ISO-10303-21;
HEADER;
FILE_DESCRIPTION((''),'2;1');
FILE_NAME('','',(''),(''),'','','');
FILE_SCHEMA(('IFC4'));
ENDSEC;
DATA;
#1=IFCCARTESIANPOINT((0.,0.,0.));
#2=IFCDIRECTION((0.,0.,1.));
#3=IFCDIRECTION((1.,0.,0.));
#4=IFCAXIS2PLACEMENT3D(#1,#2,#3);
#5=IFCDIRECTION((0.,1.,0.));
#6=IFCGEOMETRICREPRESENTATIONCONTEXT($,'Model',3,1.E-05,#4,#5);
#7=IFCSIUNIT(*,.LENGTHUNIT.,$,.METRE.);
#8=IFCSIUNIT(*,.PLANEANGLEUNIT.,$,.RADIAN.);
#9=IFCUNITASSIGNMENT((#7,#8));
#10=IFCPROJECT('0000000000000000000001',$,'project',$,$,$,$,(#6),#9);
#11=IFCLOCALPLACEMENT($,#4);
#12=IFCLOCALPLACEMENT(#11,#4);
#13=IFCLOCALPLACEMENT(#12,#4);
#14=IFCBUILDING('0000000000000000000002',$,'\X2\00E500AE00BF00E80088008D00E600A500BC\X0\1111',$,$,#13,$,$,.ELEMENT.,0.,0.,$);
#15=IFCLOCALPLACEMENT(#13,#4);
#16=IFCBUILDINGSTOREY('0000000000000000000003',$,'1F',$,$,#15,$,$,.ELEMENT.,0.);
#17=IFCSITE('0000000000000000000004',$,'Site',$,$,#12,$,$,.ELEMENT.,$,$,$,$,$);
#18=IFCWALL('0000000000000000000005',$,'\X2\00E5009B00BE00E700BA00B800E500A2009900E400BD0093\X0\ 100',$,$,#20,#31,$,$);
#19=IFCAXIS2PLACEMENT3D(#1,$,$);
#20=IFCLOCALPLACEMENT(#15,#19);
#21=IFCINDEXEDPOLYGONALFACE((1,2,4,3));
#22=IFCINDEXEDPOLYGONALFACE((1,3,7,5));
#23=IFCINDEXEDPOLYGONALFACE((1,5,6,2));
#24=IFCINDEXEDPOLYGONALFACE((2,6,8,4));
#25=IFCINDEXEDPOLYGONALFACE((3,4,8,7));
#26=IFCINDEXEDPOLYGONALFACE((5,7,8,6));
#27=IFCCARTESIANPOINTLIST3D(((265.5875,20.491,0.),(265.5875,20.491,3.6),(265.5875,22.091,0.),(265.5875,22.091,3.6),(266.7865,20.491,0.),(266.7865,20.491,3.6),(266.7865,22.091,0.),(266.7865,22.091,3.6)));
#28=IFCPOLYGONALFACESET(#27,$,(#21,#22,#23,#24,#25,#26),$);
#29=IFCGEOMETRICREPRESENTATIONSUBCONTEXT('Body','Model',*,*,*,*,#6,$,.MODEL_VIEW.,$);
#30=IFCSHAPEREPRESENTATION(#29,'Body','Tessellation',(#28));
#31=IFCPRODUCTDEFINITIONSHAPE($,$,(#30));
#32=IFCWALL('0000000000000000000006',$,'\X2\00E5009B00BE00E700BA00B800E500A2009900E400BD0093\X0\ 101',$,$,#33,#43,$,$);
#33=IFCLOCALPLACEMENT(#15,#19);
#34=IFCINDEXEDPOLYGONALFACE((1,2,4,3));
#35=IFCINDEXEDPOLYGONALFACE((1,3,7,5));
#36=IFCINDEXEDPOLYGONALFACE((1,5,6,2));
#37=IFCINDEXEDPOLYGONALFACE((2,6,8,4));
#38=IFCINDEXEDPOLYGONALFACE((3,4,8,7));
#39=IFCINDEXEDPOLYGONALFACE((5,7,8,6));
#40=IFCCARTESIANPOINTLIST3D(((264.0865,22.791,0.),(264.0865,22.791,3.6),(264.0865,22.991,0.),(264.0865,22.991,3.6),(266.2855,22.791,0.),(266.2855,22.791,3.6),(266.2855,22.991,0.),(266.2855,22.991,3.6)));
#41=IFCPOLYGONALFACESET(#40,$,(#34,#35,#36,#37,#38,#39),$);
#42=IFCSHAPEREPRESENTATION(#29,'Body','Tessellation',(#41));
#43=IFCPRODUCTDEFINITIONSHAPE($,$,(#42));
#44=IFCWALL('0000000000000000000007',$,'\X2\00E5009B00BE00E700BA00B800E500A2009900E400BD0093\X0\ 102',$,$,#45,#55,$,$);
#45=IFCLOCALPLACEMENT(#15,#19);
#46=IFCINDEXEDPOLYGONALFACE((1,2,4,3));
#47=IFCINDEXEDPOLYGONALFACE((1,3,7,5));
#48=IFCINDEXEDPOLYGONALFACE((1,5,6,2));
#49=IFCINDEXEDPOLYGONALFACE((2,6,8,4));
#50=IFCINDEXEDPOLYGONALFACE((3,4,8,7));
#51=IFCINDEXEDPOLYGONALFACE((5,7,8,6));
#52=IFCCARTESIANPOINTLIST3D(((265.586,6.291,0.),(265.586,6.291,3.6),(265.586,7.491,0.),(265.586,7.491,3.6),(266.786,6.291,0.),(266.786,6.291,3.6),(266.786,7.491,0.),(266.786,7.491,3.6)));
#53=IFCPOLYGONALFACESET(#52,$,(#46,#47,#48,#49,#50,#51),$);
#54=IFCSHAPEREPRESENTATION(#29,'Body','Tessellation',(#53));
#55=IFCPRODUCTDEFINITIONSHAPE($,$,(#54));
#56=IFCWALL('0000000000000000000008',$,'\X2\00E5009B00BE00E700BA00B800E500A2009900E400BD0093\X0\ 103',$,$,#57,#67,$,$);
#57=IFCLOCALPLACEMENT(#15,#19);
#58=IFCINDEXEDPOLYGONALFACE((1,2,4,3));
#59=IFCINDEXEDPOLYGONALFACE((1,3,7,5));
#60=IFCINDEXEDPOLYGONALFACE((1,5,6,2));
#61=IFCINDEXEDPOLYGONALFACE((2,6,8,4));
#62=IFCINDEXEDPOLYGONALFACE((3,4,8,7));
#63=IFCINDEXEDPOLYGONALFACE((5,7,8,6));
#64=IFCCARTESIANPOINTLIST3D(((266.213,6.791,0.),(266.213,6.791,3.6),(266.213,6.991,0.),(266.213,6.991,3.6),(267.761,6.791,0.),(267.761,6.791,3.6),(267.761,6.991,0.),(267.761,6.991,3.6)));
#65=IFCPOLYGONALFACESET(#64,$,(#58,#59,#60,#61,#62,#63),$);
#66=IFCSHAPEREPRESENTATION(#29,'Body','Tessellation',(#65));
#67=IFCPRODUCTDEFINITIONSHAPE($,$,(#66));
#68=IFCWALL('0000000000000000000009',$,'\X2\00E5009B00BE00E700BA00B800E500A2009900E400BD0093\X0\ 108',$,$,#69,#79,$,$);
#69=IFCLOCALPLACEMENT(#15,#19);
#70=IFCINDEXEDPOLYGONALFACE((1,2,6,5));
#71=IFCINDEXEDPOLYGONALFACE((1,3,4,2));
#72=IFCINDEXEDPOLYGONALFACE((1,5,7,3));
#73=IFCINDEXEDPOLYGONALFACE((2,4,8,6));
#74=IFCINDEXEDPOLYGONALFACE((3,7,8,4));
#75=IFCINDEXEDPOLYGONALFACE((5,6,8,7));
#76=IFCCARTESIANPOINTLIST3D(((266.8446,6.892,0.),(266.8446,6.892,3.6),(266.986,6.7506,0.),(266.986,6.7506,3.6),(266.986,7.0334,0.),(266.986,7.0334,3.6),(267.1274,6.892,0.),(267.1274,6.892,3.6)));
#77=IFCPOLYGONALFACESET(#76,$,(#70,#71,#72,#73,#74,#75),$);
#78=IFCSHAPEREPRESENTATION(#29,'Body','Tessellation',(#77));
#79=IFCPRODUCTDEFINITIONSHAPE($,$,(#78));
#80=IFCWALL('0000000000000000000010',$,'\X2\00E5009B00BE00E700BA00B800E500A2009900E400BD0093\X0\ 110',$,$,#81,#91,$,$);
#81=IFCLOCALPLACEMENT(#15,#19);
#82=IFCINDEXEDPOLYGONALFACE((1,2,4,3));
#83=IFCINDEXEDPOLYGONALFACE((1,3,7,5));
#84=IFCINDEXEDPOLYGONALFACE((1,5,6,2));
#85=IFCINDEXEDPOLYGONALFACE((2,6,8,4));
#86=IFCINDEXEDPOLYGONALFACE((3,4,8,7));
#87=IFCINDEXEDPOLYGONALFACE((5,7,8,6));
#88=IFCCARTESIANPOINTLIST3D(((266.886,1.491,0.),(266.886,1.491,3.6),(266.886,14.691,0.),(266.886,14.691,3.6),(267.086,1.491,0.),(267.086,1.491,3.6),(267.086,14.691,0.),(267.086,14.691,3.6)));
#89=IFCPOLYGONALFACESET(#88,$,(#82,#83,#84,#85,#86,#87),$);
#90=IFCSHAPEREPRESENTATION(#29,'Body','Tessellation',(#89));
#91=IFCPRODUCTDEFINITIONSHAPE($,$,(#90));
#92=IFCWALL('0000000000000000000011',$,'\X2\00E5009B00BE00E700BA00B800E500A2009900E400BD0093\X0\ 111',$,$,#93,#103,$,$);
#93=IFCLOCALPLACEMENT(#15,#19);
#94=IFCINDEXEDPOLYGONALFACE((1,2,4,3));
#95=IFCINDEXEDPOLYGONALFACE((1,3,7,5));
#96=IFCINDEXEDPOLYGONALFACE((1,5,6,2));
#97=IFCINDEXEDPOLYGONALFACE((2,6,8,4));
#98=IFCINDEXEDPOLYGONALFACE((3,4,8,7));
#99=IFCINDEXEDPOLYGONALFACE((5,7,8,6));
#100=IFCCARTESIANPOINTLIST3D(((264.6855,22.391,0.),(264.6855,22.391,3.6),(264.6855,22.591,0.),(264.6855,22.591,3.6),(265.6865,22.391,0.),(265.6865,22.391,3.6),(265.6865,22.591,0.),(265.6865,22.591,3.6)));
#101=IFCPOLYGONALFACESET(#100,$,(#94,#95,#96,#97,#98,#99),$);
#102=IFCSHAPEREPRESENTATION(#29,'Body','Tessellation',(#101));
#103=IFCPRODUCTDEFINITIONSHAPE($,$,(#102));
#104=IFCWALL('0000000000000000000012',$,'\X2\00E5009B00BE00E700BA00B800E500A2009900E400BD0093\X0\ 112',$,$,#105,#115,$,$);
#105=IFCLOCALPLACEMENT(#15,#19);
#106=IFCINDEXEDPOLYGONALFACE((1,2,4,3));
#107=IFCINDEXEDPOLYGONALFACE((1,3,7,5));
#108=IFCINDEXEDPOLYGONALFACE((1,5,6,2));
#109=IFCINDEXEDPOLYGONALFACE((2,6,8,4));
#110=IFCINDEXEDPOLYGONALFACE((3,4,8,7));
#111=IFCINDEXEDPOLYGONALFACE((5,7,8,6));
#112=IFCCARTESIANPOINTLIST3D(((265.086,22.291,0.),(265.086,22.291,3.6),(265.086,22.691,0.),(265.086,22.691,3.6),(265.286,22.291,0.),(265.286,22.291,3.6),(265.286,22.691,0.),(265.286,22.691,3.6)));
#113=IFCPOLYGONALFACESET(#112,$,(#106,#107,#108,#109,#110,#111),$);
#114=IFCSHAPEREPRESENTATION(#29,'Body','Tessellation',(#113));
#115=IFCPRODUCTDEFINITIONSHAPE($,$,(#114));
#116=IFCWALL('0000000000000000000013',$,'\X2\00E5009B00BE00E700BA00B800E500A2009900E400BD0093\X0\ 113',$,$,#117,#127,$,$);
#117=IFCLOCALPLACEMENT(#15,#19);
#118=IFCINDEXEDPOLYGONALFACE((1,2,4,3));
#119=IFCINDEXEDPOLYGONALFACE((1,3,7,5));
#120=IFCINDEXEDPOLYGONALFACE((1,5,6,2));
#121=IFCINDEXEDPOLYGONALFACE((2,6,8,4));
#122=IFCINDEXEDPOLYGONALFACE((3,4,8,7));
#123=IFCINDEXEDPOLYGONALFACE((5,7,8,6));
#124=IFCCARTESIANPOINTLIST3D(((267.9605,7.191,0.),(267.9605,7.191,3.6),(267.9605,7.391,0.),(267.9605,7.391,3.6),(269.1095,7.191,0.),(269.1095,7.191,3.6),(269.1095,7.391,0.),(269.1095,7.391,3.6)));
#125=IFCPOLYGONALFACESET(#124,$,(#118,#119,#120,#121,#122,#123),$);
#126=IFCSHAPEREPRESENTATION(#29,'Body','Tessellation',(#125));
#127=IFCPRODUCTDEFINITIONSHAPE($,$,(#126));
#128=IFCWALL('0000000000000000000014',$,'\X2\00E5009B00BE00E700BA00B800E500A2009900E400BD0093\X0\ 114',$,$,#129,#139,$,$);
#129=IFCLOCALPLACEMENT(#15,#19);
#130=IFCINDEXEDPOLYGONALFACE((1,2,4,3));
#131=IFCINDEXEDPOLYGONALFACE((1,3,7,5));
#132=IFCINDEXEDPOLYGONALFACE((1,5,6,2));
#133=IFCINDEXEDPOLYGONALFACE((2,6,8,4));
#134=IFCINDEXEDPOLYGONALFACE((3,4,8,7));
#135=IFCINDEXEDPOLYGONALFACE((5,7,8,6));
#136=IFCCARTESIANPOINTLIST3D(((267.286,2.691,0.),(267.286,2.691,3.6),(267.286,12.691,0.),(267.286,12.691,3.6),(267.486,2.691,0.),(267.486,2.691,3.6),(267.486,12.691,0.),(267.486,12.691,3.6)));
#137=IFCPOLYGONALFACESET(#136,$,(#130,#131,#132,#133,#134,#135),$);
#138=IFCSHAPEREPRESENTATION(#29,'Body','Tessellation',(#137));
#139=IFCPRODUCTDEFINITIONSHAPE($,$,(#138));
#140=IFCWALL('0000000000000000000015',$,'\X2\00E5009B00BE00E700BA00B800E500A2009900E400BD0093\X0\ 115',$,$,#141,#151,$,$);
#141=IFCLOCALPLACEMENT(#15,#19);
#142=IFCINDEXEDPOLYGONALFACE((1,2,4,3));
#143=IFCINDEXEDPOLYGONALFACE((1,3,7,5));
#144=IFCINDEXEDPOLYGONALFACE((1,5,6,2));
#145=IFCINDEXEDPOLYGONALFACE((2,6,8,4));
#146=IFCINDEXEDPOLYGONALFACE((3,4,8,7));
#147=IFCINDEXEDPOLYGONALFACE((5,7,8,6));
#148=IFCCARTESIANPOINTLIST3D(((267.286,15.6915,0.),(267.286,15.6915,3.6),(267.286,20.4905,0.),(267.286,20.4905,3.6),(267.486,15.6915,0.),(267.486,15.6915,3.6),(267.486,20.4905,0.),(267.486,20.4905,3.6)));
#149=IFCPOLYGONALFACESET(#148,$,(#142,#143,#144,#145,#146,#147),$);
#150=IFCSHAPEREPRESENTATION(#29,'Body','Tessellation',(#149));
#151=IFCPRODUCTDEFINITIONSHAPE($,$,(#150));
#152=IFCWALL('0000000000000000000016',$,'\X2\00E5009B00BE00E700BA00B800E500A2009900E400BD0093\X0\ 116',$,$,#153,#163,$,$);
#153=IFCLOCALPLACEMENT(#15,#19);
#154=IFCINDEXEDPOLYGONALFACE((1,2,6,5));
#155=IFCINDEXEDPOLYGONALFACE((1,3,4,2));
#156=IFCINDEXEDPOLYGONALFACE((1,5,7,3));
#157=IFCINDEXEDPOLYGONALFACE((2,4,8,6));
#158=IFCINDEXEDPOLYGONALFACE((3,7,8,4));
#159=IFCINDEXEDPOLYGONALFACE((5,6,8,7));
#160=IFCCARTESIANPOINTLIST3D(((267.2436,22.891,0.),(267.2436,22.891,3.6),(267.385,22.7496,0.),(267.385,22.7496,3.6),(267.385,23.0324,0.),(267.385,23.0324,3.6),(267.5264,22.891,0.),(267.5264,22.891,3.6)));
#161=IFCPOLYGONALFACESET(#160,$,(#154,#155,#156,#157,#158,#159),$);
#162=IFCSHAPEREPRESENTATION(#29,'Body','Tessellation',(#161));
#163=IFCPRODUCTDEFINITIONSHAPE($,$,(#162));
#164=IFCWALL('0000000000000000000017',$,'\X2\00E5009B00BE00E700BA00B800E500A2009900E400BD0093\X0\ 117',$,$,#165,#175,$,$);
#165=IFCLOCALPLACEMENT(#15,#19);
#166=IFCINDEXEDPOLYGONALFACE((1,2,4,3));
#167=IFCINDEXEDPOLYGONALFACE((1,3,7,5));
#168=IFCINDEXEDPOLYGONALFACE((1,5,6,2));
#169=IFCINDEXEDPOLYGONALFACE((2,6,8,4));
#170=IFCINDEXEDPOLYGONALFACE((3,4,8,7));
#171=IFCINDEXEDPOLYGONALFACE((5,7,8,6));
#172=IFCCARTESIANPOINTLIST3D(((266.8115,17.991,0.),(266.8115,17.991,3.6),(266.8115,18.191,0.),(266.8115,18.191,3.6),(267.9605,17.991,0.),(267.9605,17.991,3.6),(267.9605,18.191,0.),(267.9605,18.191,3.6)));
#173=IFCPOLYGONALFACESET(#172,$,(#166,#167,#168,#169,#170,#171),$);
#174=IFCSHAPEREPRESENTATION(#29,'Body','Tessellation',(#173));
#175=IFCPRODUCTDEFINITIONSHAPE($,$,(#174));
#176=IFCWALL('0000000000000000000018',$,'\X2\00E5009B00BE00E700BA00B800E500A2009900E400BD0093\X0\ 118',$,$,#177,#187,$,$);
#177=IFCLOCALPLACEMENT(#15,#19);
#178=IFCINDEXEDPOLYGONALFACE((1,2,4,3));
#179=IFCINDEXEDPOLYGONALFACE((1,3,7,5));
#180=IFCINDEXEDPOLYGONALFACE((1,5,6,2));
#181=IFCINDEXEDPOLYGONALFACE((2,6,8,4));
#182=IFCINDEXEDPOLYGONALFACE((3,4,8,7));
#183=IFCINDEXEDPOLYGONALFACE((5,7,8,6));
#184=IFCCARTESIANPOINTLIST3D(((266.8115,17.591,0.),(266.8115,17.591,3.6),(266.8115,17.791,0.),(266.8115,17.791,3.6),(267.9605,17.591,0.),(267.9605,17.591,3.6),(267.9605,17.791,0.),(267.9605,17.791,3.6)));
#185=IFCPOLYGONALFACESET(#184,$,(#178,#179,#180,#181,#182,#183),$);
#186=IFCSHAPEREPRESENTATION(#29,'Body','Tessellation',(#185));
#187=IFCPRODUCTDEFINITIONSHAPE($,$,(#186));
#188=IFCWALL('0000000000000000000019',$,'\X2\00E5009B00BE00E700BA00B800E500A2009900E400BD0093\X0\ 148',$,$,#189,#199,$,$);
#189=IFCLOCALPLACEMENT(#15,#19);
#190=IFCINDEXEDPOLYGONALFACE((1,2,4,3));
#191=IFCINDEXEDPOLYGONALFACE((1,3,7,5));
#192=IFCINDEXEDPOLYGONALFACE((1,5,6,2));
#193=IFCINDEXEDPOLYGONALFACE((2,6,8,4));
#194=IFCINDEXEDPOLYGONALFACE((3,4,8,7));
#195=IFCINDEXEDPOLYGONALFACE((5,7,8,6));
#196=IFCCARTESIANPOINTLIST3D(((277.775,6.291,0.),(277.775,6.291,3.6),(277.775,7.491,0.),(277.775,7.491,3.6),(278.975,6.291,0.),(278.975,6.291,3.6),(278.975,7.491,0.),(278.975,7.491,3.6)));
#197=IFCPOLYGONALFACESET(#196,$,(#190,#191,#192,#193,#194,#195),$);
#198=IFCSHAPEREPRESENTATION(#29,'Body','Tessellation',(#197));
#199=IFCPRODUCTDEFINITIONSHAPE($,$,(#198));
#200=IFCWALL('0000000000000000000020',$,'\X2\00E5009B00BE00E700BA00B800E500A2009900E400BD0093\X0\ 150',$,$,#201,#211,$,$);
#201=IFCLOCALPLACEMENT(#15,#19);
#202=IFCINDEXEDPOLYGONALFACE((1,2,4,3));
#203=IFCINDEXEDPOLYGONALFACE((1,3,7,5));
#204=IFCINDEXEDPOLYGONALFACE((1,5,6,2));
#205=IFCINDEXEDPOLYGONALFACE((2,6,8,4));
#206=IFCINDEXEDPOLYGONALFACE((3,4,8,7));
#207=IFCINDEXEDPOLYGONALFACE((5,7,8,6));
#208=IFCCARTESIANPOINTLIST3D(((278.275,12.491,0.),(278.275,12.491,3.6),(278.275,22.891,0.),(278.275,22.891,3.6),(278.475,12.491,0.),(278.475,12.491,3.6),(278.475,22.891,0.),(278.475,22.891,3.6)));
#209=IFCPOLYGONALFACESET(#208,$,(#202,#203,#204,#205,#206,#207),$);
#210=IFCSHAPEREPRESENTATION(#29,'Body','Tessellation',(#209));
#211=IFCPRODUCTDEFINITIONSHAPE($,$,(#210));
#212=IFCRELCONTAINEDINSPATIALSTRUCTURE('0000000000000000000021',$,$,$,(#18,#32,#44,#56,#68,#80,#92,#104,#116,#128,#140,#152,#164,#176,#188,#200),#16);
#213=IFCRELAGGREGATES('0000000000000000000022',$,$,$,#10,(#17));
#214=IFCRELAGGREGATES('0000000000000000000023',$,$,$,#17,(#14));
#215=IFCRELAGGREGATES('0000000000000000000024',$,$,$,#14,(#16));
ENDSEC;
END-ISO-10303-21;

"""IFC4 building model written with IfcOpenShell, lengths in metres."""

from ifc_helpers import new_model, si_unit, direction, frame, frame_2d, origin_with_axes, place, context, subcontext, project, spatial, rectangle, extrude, element, save


model = new_model("IFC4")

# Units and contexts
model_context = context("Model", 3, precision=1e-05, world=origin_with_axes(), true_north=direction((0.0, 1.0, 0.0)))
body_context = subcontext(model_context, "Body", "Model", "MODEL_VIEW")
ifc_project = project(units=[si_unit("LENGTHUNIT", "METRE"), si_unit("PLANEANGLEUNIT", "RADIAN")], contexts=[model_context])

# Site, building, storey
placement = place(None, origin_with_axes())
site_placement = place(placement, origin_with_axes())
site = spatial("IfcSite", under=ifc_project, at=site_placement, Name="Site", CompositionType="ELEMENT")
building_placement = place(site_placement, origin_with_axes())
building = spatial("IfcBuilding", under=site, at=building_placement, Name="å®¿è\u0088\u008dæ¥¼1111", CompositionType="ELEMENT", ElevationOfRefHeight=0.0, ElevationOfTerrain=0.0)
storey_placement = place(building_placement, origin_with_axes())
storey = spatial("IfcBuildingStorey", under=building, at=storey_placement, Name="1F", CompositionType="ELEMENT", Elevation=0.0)

# Walls
wall_1_placement = place(storey_placement, frame((266.187, 21.291, 0.0), z_axis=(0.0, 0.0, 1.0), x_axis=(1.0, 0.0, 0.0)))
element("IfcWall", 1, at=wall_1_placement, inside=storey, Name="å\u009b¾çº¸å¢\u0099ä½\u0093 100", context=body_context, shape_type="SweptSolid", body=[
    extrude(rectangle(XDim=1.199, YDim=1.6, at=frame_2d((0.0, 0.0), x_axis=(1.0, 0.0, 0.0))), frame((0.0, 0.0, 0.0), z_axis=(0.0, 0.0, 1.0)), (0.0, 0.0, 1.0), 3.6),
])
wall_2_placement = place(storey_placement, frame((265.186, 22.891, 0.0), z_axis=(0.0, 0.0, 1.0), x_axis=(1.0, 0.0, 0.0)))
element("IfcWall", 2, at=wall_2_placement, inside=storey, Name="å\u009b¾çº¸å¢\u0099ä½\u0093 101", context=body_context, shape_type="SweptSolid", body=[
    extrude(rectangle(XDim=2.199, YDim=0.2, at=frame_2d((0.0, 0.0), x_axis=(1.0, 0.0, 0.0))), frame((0.0, 0.0, 0.0), z_axis=(0.0, 0.0, 1.0)), (0.0, 0.0, 1.0), 3.6),
])
wall_3_placement = place(storey_placement, frame((266.186, 6.891, 0.0), z_axis=(0.0, 0.0, 1.0), x_axis=(1.0, 0.0, 0.0)))
element("IfcWall", 3, at=wall_3_placement, inside=storey, Name="å\u009b¾çº¸å¢\u0099ä½\u0093 102", context=body_context, shape_type="SweptSolid", body=[
    extrude(rectangle(XDim=1.2, YDim=1.2, at=frame_2d((0.0, 0.0), x_axis=(1.0, 0.0, 0.0))), frame((0.0, 0.0, 0.0), z_axis=(0.0, 0.0, 1.0)), (0.0, 0.0, 1.0), 3.6),
])
wall_4_placement = place(storey_placement, frame((266.987, 6.891, 0.0), z_axis=(0.0, 0.0, 1.0), x_axis=(1.0, 0.0, 0.0)))
element("IfcWall", 4, at=wall_4_placement, inside=storey, Name="å\u009b¾çº¸å¢\u0099ä½\u0093 103", context=body_context, shape_type="SweptSolid", body=[
    extrude(rectangle(XDim=1.548, YDim=0.2, at=frame_2d((0.0, 0.0), x_axis=(1.0, 0.0, 0.0))), frame((0.0, 0.0, 0.0), z_axis=(0.0, 0.0, 1.0)), (0.0, 0.0, 1.0), 3.6),
])
wall_5_placement = place(storey_placement, frame((266.986, 6.892, 0.0), z_axis=(0.0, 0.0, 1.0), x_axis=(0.707107, -0.707107, 0.0)))
element("IfcWall", 5, at=wall_5_placement, inside=storey, Name="å\u009b¾çº¸å¢\u0099ä½\u0093 108", context=body_context, shape_type="SweptSolid", body=[
    extrude(rectangle(XDim=0.2, YDim=0.2, at=frame_2d((0.0, 0.0), x_axis=(1.0, 0.0, 0.0))), frame((0.0, 0.0, 0.0), z_axis=(0.0, 0.0, 1.0)), (0.0, 0.0, 1.0), 3.6),
])
wall_6_placement = place(storey_placement, frame((266.986, 8.091, 0.0), z_axis=(0.0, 0.0, 1.0), x_axis=(0.0, 1.0, 0.0)))
element("IfcWall", 6, at=wall_6_placement, inside=storey, Name="å\u009b¾çº¸å¢\u0099ä½\u0093 110", context=body_context, shape_type="SweptSolid", body=[
    extrude(rectangle(XDim=13.2, YDim=0.2, at=frame_2d((0.0, 0.0), x_axis=(1.0, 0.0, 0.0))), frame((0.0, 0.0, 0.0), z_axis=(0.0, 0.0, 1.0)), (0.0, 0.0, 1.0), 3.6),
])
wall_7_placement = place(storey_placement, frame((265.186, 22.491, 0.0), z_axis=(0.0, 0.0, 1.0), x_axis=(1.0, 0.0, 0.0)))
element("IfcWall", 7, at=wall_7_placement, inside=storey, Name="å\u009b¾çº¸å¢\u0099ä½\u0093 111", context=body_context, shape_type="SweptSolid", body=[
    extrude(rectangle(XDim=1.001, YDim=0.2, at=frame_2d((0.0, 0.0), x_axis=(1.0, 0.0, 0.0))), frame((0.0, 0.0, 0.0), z_axis=(0.0, 0.0, 1.0)), (0.0, 0.0, 1.0), 3.6),
])
wall_8_placement = place(storey_placement, frame((265.186, 22.491, 0.0), z_axis=(0.0, 0.0, 1.0), x_axis=(0.0, 1.0, 0.0)))
element("IfcWall", 8, at=wall_8_placement, inside=storey, Name="å\u009b¾çº¸å¢\u0099ä½\u0093 112", context=body_context, shape_type="SweptSolid", body=[
    extrude(rectangle(XDim=0.4, YDim=0.2, at=frame_2d((0.0, 0.0), x_axis=(1.0, 0.0, 0.0))), frame((0.0, 0.0, 0.0), z_axis=(0.0, 0.0, 1.0)), (0.0, 0.0, 1.0), 3.6),
])
wall_9_placement = place(storey_placement, frame((268.535, 7.291, 0.0), z_axis=(0.0, 0.0, 1.0), x_axis=(-1.0, 0.0, 0.0)))
element("IfcWall", 9, at=wall_9_placement, inside=storey, Name="å\u009b¾çº¸å¢\u0099ä½\u0093 113", context=body_context, shape_type="SweptSolid", body=[
    extrude(rectangle(XDim=1.149, YDim=0.2, at=frame_2d((0.0, 0.0), x_axis=(1.0, 0.0, 0.0))), frame((0.0, 0.0, 0.0), z_axis=(0.0, 0.0, 1.0)), (0.0, 0.0, 1.0), 3.6),
])
wall_10_placement = place(storey_placement, frame((267.386, 7.691, 0.0), z_axis=(0.0, 0.0, 1.0), x_axis=(0.0, 1.0, 0.0)))
element("IfcWall", 10, at=wall_10_placement, inside=storey, Name="å\u009b¾çº¸å¢\u0099ä½\u0093 114", context=body_context, shape_type="SweptSolid", body=[
    extrude(rectangle(XDim=10.0, YDim=0.2, at=frame_2d((0.0, 0.0), x_axis=(1.0, 0.0, 0.0))), frame((0.0, 0.0, 0.0), z_axis=(0.0, 0.0, 1.0)), (0.0, 0.0, 1.0), 3.6),
])
wall_11_placement = place(storey_placement, frame((267.386, 18.091, 0.0), z_axis=(0.0, 0.0, 1.0), x_axis=(0.0, 1.0, 0.0)))
element("IfcWall", 11, at=wall_11_placement, inside=storey, Name="å\u009b¾çº¸å¢\u0099ä½\u0093 115", context=body_context, shape_type="SweptSolid", body=[
    extrude(rectangle(XDim=4.799, YDim=0.2, at=frame_2d((0.0, 0.0), x_axis=(1.0, 0.0, 0.0))), frame((0.0, 0.0, 0.0), z_axis=(0.0, 0.0, 1.0)), (0.0, 0.0, 1.0), 3.6),
])
wall_12_placement = place(storey_placement, frame((267.385, 22.891, 0.0), z_axis=(0.0, 0.0, 1.0), x_axis=(0.707107, -0.707107, 0.0)))
element("IfcWall", 12, at=wall_12_placement, inside=storey, Name="å\u009b¾çº¸å¢\u0099ä½\u0093 116", context=body_context, shape_type="SweptSolid", body=[
    extrude(rectangle(XDim=0.2, YDim=0.2, at=frame_2d((0.0, 0.0), x_axis=(1.0, 0.0, 0.0))), frame((0.0, 0.0, 0.0), z_axis=(0.0, 0.0, 1.0)), (0.0, 0.0, 1.0), 3.6),
])
for number, where, z_axis, x_axis, name in (
    (13, (267.386, 18.091, 0.0), (0.0, 0.0, 1.0), (1.0, 0.0, 0.0), "å\u009b¾çº¸å¢\u0099ä½\u0093 117"),
    (14, (267.386, 17.691, 0.0), (0.0, 0.0, 1.0), (1.0, 0.0, 0.0), "å\u009b¾çº¸å¢\u0099ä½\u0093 118"),
):
    element("IfcWall", number, at=place(storey_placement, frame(where, z_axis=z_axis, x_axis=x_axis)), inside=storey, Name=name, context=body_context, shape_type="SweptSolid", body=[
        extrude(rectangle(XDim=1.149, YDim=0.2, at=frame_2d((0.0, 0.0), x_axis=(1.0, 0.0, 0.0))), frame((0.0, 0.0, 0.0), z_axis=(0.0, 0.0, 1.0)), (0.0, 0.0, 1.0), 3.6),
    ])
wall_13_placement = place(storey_placement, frame((278.375, 6.891, 0.0), z_axis=(0.0, 0.0, 1.0), x_axis=(1.0, 0.0, 0.0)))
element("IfcWall", 15, at=wall_13_placement, inside=storey, Name="å\u009b¾çº¸å¢\u0099ä½\u0093 148", context=body_context, shape_type="SweptSolid", body=[
    extrude(rectangle(XDim=1.2, YDim=1.2, at=frame_2d((0.0, 0.0), x_axis=(1.0, 0.0, 0.0))), frame((0.0, 0.0, 0.0), z_axis=(0.0, 0.0, 1.0)), (0.0, 0.0, 1.0), 3.6),
])
wall_14_placement = place(storey_placement, frame((278.375, 17.691, 0.0), z_axis=(0.0, 0.0, 1.0), x_axis=(0.0, -1.0, 0.0)))
element("IfcWall", 16, at=wall_14_placement, inside=storey, Name="å\u009b¾çº¸å¢\u0099ä½\u0093 150", context=body_context, shape_type="SweptSolid", body=[
    extrude(rectangle(XDim=10.4, YDim=0.2, at=frame_2d((0.0, 0.0), x_axis=(1.0, 0.0, 0.0))), frame((0.0, 0.0, 0.0), z_axis=(0.0, 0.0, 1.0)), (0.0, 0.0, 1.0), 3.6),
])

save(model, "model.ifc")
